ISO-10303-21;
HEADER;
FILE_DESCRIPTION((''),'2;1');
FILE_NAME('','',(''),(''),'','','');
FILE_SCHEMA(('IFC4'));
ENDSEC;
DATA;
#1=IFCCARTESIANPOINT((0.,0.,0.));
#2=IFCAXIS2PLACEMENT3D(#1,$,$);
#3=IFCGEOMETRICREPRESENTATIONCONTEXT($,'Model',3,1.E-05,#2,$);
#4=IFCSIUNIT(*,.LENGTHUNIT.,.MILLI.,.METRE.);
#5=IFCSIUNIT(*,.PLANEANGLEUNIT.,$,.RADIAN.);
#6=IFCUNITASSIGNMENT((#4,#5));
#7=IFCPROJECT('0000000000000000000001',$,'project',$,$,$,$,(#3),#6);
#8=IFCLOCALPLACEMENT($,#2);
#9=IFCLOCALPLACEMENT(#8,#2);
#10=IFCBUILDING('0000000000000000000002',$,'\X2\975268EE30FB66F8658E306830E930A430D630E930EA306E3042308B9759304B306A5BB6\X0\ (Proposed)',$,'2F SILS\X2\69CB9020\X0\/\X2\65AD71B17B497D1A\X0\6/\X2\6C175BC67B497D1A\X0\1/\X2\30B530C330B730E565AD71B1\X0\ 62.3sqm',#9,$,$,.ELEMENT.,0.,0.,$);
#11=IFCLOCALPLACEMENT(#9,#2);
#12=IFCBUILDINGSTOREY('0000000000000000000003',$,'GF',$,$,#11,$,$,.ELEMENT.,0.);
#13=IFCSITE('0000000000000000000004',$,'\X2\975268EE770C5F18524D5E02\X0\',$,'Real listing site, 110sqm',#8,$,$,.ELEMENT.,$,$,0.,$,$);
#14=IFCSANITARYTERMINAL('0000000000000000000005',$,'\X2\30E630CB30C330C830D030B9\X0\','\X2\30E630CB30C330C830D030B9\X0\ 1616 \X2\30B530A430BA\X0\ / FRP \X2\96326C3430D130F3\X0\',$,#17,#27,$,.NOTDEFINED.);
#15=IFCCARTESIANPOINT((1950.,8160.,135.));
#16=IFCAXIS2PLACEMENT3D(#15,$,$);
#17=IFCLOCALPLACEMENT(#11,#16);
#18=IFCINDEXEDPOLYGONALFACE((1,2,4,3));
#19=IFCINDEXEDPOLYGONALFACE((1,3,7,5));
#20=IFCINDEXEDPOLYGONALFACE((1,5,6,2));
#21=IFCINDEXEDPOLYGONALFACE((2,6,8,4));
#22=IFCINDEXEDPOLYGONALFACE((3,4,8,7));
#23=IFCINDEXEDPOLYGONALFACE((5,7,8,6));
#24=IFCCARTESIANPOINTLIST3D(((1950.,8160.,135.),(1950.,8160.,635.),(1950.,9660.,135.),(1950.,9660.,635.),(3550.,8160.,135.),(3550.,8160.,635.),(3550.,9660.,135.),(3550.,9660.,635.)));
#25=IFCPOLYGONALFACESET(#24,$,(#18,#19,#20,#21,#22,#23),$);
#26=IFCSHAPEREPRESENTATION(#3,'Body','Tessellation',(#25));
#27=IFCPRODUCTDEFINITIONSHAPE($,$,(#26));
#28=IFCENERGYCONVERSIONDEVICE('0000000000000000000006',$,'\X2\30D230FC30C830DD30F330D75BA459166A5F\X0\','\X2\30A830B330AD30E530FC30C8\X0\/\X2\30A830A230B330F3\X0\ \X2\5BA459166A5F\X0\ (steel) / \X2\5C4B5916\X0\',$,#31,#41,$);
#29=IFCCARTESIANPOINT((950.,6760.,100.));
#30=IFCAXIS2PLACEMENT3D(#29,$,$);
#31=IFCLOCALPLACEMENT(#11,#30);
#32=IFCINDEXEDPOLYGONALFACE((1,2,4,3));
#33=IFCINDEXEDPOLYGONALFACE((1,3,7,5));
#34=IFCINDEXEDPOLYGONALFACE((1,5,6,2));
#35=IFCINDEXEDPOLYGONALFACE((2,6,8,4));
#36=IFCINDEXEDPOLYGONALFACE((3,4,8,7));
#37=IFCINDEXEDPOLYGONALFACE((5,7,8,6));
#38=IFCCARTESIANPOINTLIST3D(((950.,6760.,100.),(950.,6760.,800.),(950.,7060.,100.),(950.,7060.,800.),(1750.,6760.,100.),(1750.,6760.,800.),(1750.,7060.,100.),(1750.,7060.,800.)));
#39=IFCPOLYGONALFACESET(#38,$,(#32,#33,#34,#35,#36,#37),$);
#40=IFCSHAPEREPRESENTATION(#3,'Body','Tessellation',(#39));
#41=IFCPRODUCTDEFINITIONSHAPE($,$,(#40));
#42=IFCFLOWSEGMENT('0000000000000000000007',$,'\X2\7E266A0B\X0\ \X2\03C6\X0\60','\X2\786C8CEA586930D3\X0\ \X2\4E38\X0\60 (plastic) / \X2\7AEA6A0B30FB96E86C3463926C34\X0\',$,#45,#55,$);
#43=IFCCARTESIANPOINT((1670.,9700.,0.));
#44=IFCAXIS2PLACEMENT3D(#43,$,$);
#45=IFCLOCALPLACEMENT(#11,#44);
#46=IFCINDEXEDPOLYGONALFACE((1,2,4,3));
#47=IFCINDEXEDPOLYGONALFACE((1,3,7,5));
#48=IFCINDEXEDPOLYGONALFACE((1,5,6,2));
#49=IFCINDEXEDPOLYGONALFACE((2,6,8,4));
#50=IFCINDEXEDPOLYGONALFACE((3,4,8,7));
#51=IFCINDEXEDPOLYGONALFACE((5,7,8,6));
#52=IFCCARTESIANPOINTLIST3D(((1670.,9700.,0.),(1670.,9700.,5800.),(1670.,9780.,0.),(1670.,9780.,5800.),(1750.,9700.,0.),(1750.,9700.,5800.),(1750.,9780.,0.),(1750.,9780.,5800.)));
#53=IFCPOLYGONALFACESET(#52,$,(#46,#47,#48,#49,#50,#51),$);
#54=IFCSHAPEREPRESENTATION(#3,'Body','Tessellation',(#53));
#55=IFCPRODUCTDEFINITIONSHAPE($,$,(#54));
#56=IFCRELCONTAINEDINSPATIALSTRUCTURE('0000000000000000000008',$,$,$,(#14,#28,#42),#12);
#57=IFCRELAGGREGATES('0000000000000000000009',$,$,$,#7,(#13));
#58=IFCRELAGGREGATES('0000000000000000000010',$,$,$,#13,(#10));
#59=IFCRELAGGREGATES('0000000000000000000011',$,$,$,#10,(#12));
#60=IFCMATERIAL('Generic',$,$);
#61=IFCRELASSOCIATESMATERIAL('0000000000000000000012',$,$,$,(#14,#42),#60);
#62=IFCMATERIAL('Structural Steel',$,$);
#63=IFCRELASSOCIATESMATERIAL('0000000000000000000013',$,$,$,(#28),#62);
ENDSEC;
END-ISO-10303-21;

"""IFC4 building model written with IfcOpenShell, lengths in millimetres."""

from ifc_helpers import new_model, si_unit, frame, frame_2d, origin, place, context, project, spatial, rectangle, extrude, material, element, save


model = new_model("IFC4")

# Units and contexts
model_context = context("Model", 3, precision=1e-05, world=origin())
ifc_project = project(units=[si_unit("LENGTHUNIT", "METRE", prefix="MILLI"), si_unit("PLANEANGLEUNIT", "RADIAN")], contexts=[model_context])

# Site, building, storey
site_placement = place(None, origin())
site = spatial("IfcSite", under=ifc_project, at=site_placement, Name="青森県弘前市", ObjectType="Real listing site, 110sqm", CompositionType="ELEMENT", RefElevation=0.0)
building_placement = place(site_placement, origin())
building = spatial("IfcBuilding", under=site, at=building_placement, Name="青森・書斎とライブラリのある静かな家 (Proposed)", ObjectType="2F SILS構造/断熱等級6/気密等級1/サッシュ断熱 62.3sqm", CompositionType="ELEMENT", ElevationOfRefHeight=0.0, ElevationOfTerrain=0.0)
storey_placement = place(building_placement, origin())
storey = spatial("IfcBuildingStorey", under=building, at=storey_placement, Name="GF", CompositionType="ELEMENT", Elevation=0.0)

# Shared definitions
ifc_material_1 = material(Name="Generic")

# Sanitary terminal
sanitary_terminal_placement = place(storey_placement, frame((1950.0, 8160.0, 135.0)))
element("IfcSanitaryTerminal", 1, at=sanitary_terminal_placement, inside=storey, material=ifc_material_1, Name="ユニットバス", Description="ユニットバス 1616 サイズ / FRP 防水パン", PredefinedType="NOTDEFINED", context=model_context, shape_type="SweptSolid", body=[
    extrude(rectangle(XDim=1600.0, YDim=1500.0, at=frame_2d((800.0, 750.0))), frame((1950.0, 8160.0, 135.0)), (0.0, 0.0, 1.0), 500.0),
])

# Energy conversion device
ifc_material_2 = material(Name="Structural Steel")
energy_conversion_device_placement = place(storey_placement, frame((950.0, 6760.0, 100.0)))
element("IfcEnergyConversionDevice", 2, at=energy_conversion_device_placement, inside=storey, material=ifc_material_2, Name="ヒートポンプ室外機", Description="エコキュート/エアコン 室外機 (steel) / 屋外", context=model_context, shape_type="SweptSolid", body=[
    extrude(rectangle(XDim=800.0, YDim=300.0, at=frame_2d((400.0, 150.0))), frame((950.0, 6760.0, 100.0)), (0.0, 0.0, 1.0), 700.0),
])

# Flow segment
flow_segment_placement = place(storey_placement, frame((1670.0, 9700.0, 0.0)))
element("IfcFlowSegment", 3, at=flow_segment_placement, inside=storey, material=ifc_material_1, Name="縦樋 φ60", Description="硬質塩ビ 丸60 (plastic) / 竪樋・雨水排水", context=model_context, shape_type="SweptSolid", body=[
    extrude(rectangle(XDim=80.0, YDim=80.0, at=frame_2d((40.0, 40.0))), frame((1670.0, 9700.0, 0.0)), (0.0, 0.0, 1.0), 5800.0),
])

save(model, "model.ifc")
